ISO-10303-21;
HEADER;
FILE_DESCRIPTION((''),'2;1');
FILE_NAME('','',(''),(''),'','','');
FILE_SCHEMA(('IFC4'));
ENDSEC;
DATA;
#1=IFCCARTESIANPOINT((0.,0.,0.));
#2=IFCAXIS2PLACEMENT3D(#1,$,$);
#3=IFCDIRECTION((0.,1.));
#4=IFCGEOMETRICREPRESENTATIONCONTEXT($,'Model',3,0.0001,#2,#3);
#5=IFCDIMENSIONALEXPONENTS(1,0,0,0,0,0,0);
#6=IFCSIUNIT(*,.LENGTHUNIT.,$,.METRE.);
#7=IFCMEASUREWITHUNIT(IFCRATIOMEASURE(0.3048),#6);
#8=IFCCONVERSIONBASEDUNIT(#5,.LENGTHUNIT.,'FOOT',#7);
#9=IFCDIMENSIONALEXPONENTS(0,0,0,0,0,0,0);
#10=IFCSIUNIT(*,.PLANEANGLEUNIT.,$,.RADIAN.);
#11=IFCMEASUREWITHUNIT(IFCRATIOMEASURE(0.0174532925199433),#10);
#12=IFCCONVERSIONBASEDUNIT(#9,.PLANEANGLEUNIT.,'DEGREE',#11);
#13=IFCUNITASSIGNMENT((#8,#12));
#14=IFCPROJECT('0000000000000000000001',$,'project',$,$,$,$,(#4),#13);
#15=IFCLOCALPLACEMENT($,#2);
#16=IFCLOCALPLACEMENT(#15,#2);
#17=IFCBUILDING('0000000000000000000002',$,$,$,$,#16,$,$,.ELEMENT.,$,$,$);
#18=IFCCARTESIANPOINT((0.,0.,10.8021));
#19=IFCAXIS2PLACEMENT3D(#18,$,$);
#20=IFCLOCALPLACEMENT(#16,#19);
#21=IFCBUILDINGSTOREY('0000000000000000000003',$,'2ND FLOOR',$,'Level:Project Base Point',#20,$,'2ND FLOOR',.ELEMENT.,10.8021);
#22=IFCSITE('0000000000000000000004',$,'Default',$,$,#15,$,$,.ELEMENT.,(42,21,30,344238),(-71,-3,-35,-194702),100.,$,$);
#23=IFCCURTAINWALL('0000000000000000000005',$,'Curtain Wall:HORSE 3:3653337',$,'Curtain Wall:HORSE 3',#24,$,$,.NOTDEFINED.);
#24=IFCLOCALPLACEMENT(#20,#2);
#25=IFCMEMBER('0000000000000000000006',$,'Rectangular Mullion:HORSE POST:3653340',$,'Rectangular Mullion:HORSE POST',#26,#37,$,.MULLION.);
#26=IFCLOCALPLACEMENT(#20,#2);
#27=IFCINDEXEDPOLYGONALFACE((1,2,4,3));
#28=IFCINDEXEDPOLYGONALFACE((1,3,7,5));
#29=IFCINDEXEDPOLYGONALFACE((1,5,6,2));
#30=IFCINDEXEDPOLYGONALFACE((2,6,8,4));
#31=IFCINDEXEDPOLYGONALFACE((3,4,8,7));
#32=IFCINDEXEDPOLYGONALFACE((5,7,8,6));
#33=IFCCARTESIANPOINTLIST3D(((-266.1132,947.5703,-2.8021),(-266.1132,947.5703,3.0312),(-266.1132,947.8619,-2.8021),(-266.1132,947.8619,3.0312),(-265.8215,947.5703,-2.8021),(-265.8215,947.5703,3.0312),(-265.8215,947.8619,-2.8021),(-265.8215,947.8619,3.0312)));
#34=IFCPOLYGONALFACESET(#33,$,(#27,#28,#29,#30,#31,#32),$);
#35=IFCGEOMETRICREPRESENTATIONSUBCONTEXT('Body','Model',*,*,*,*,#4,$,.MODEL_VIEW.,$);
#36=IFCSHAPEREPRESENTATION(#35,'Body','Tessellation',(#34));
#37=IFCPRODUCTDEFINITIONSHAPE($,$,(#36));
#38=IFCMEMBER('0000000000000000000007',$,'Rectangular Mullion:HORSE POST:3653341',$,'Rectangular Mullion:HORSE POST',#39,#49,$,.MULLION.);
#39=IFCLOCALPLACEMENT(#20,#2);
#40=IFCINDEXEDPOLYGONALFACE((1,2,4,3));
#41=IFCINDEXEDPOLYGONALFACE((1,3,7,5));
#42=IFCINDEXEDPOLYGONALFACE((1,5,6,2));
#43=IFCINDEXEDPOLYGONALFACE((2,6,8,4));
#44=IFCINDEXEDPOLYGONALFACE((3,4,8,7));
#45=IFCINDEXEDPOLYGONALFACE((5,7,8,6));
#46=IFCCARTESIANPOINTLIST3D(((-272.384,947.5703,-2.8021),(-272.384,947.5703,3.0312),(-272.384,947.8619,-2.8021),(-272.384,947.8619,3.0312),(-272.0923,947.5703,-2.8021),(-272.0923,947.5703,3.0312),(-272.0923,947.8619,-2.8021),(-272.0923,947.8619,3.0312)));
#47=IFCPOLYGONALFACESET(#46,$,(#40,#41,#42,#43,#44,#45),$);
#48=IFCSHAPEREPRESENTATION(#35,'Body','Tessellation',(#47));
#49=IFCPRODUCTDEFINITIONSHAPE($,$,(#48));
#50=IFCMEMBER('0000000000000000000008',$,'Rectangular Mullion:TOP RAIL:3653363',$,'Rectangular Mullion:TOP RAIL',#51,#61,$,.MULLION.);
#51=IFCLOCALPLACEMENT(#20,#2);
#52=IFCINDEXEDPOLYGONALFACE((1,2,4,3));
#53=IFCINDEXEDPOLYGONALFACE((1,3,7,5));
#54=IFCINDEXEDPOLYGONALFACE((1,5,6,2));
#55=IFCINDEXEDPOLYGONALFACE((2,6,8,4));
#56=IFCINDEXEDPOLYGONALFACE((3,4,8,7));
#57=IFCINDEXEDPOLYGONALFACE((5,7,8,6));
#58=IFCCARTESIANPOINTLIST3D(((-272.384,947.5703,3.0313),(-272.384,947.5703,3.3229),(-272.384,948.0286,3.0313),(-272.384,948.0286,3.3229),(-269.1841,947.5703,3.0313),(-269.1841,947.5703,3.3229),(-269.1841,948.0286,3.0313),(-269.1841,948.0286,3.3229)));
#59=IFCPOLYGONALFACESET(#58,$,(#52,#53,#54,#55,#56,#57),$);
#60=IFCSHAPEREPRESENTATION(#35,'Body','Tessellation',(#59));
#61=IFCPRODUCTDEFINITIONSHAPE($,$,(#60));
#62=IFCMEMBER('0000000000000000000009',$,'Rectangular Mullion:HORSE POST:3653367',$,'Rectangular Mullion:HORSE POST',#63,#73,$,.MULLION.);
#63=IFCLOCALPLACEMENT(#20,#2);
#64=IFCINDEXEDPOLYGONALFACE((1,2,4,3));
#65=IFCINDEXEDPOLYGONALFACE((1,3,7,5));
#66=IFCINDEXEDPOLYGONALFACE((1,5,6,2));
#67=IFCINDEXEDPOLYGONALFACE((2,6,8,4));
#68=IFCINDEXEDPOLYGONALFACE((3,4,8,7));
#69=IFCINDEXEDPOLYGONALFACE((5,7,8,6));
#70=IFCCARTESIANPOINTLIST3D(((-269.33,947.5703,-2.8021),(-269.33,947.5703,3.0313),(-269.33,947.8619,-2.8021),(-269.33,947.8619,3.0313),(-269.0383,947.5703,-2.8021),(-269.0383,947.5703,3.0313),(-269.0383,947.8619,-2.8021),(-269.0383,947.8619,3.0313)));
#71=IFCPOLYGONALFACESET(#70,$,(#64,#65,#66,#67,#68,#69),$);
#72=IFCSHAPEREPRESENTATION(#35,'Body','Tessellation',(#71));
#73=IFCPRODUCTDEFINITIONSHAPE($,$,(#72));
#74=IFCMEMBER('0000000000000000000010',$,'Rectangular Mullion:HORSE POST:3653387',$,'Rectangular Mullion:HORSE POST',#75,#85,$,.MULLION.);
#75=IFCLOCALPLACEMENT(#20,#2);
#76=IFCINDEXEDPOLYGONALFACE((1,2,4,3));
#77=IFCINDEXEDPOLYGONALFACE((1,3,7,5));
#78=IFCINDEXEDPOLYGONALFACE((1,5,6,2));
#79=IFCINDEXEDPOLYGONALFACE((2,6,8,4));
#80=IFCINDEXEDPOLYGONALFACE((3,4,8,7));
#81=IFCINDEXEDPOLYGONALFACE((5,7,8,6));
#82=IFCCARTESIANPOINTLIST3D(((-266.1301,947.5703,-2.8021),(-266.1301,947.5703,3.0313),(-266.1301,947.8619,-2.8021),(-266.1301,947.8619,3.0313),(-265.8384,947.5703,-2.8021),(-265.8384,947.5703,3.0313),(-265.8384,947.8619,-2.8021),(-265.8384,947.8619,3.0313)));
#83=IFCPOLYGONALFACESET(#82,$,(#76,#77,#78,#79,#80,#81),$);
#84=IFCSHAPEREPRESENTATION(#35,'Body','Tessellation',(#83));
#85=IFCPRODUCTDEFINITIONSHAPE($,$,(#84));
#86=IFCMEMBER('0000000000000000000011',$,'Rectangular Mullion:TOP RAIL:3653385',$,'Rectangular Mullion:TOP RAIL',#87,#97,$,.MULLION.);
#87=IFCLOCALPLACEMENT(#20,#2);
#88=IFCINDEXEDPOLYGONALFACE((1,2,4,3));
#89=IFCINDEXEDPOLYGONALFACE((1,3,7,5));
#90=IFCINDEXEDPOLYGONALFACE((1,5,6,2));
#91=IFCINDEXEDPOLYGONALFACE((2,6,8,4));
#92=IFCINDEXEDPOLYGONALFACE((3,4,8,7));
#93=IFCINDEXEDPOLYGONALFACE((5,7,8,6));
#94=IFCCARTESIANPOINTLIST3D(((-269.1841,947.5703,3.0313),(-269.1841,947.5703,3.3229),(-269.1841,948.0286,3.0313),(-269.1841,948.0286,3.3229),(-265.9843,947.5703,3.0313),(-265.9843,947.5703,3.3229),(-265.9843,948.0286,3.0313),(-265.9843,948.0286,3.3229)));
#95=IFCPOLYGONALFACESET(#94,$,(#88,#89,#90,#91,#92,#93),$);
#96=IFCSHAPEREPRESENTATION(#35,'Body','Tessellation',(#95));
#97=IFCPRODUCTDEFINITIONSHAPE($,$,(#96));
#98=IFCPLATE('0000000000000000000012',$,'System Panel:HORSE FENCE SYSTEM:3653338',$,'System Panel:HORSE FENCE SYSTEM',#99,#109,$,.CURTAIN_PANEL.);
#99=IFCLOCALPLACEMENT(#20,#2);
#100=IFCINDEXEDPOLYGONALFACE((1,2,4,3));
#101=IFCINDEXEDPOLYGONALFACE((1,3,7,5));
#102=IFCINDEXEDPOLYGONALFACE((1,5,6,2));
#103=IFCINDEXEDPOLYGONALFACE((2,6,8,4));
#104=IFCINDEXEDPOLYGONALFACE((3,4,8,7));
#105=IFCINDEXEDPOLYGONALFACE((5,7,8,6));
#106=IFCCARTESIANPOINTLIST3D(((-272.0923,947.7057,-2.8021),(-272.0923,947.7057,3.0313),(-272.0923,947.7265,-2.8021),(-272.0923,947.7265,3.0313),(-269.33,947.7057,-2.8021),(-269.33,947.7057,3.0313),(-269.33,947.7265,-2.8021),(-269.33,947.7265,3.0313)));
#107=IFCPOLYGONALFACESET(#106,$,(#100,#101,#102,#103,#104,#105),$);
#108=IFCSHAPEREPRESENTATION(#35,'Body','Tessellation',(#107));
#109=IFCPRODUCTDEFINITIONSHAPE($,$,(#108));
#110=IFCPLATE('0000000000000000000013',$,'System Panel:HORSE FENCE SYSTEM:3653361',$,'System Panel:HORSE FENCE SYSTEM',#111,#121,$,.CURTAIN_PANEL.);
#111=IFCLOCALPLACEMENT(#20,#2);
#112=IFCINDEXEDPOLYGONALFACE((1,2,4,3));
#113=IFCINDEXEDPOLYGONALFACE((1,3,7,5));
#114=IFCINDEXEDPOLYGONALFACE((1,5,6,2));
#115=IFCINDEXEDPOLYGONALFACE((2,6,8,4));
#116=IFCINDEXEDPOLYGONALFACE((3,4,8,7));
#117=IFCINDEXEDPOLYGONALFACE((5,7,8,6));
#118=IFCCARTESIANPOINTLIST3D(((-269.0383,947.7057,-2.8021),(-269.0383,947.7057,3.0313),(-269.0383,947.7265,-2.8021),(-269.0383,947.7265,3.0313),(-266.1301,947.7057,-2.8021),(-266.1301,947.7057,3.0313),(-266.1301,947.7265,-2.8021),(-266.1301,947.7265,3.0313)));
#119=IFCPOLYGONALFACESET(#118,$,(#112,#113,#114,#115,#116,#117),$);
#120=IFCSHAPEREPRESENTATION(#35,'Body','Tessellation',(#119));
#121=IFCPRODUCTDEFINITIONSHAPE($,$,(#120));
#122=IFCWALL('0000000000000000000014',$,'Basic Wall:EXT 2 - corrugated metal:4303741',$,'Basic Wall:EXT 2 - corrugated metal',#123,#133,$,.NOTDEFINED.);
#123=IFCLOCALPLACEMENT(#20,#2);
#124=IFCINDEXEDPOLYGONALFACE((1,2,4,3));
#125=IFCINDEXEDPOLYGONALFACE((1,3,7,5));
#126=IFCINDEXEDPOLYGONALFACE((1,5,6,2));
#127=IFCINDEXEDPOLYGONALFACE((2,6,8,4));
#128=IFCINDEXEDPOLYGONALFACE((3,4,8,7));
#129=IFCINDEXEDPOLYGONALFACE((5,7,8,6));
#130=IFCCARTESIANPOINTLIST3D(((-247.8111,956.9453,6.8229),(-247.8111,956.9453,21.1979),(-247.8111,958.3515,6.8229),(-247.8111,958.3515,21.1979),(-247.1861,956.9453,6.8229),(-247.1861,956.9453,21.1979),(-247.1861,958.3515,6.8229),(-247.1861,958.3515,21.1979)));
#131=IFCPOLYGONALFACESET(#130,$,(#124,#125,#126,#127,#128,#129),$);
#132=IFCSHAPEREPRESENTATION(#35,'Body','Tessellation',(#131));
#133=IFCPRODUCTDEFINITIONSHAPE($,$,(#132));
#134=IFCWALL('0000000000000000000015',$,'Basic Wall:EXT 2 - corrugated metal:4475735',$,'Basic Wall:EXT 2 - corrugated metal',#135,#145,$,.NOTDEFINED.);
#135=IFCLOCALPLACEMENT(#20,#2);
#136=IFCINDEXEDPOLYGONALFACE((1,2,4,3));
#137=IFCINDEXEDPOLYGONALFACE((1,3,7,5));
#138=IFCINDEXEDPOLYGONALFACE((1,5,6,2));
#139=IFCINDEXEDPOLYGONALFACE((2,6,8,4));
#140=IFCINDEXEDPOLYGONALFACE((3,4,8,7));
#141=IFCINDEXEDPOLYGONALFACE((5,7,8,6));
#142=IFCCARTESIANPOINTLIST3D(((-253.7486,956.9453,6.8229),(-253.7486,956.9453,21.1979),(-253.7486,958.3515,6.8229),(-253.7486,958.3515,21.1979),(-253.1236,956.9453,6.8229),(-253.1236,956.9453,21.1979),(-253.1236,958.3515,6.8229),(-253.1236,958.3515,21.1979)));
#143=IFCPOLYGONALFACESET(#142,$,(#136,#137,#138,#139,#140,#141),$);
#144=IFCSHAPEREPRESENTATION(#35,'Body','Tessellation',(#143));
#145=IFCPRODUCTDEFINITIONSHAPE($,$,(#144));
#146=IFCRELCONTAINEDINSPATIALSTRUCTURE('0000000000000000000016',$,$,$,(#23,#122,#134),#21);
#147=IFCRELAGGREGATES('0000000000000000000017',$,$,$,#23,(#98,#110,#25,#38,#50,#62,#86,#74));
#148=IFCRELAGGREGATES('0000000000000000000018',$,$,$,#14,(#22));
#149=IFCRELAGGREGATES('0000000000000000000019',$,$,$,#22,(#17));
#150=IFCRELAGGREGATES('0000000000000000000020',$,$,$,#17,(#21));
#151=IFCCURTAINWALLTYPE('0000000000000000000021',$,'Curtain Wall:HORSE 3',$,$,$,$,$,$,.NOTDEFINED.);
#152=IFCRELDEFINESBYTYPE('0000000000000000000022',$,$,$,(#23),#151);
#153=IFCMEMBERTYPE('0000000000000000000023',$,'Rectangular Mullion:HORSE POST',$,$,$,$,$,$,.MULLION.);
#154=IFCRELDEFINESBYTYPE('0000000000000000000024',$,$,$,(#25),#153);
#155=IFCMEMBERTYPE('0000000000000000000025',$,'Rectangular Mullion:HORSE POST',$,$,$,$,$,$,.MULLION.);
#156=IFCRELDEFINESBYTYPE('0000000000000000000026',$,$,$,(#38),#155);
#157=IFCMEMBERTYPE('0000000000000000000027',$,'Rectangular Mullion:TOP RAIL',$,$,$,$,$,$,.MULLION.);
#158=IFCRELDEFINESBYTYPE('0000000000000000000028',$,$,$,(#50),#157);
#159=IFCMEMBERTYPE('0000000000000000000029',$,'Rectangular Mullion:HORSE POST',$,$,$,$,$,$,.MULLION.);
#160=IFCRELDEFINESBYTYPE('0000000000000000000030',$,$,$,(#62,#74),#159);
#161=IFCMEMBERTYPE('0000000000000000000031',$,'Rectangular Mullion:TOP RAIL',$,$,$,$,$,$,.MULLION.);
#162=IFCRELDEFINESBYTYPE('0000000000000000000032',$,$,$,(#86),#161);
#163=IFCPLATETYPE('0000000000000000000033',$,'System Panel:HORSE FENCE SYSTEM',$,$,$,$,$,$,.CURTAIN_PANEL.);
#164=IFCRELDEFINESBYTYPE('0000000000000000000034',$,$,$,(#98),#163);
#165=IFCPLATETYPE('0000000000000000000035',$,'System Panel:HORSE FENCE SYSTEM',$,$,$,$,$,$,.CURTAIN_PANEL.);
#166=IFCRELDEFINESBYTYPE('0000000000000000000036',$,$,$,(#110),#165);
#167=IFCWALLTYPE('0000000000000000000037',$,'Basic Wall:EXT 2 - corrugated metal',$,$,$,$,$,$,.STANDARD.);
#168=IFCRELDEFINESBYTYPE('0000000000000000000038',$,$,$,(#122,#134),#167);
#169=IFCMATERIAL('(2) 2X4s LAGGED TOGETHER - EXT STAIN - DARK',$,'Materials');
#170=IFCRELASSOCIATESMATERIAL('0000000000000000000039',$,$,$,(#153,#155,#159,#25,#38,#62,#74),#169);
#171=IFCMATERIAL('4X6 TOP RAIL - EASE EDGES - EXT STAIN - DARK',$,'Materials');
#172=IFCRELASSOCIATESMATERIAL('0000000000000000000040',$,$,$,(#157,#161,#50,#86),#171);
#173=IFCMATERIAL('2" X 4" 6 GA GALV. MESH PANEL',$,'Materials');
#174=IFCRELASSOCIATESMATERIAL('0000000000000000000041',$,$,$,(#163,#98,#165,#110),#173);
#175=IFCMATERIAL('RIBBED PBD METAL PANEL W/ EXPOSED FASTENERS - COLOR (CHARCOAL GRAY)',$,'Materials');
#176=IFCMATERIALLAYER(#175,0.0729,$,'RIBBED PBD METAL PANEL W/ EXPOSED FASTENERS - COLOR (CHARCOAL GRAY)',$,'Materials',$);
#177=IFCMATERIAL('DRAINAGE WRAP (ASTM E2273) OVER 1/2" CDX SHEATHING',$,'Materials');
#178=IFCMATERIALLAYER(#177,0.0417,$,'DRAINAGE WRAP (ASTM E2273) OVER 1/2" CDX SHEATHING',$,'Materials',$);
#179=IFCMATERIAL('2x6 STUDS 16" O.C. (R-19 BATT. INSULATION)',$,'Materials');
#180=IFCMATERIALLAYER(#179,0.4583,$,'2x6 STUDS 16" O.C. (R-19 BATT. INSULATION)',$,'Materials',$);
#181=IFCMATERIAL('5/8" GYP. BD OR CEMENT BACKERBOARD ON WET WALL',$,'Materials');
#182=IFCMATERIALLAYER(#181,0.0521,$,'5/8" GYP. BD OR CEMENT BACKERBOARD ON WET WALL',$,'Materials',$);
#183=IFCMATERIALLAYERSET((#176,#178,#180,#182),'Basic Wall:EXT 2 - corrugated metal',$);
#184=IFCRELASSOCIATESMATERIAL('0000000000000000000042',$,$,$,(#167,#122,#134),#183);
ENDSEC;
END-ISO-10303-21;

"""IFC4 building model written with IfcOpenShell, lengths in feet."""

from ifc_helpers import new_model, entity, si_unit, converted_unit, direction, frame, frame_2d, origin, origin_2d_with_axis, place, context, subcontext, project, spatial, rectangle, extrude, source, transform, mapped, material, layer, layer_set, layer_usage, material_profile, profile_set, profile_usage, type_object, type_shapes, element, aggregate, save


model = new_model("IFC4")

# Units and contexts
model_context = context("Model", 3, precision=0.0001, world=origin(), true_north=direction((0.0, 1.0)))
body_context = subcontext(model_context, "Body", "Model", "MODEL_VIEW")
ifc_project = project(units=[converted_unit("LENGTHUNIT", "FOOT", entity("IfcRatioMeasure", 0.3048), si_unit("LENGTHUNIT", "METRE"), dimensions=[1, 0, 0, 0, 0, 0, 0]), converted_unit("PLANEANGLEUNIT", "DEGREE", entity("IfcRatioMeasure", 0.0174532925199433), si_unit("PLANEANGLEUNIT", "RADIAN"), dimensions=[0, 0, 0, 0, 0, 0, 0])], contexts=[model_context])

# Site, building, storey
site_placement = place(None, origin())
site = spatial("IfcSite", under=ifc_project, at=site_placement, Name="Default", CompositionType="ELEMENT", RefLatitude=(42, 21, 30, 344238), RefLongitude=(-71, -3, -35, -194702), RefElevation=100.0)
building_placement = place(site_placement, origin())
building = spatial("IfcBuilding", under=site, at=building_placement, CompositionType="ELEMENT")
storey_placement = place(building_placement, frame((0.0, 0.0, 10.8021)))
storey = spatial("IfcBuildingStorey", under=building, at=storey_placement, Name="2ND FLOOR", ObjectType="Level:Project Base Point", LongName="2ND FLOOR", CompositionType="ELEMENT", Elevation=10.8021)

# Curtain wall, members, plates
curtain_wall_type = type_object("IfcCurtainWallType", Name="Curtain Wall:HORSE 3", PredefinedType="NOTDEFINED")
curtain_wall_placement = place(storey_placement, frame((0.0, 0.0, -10.8021)))
curtain_wall = element("IfcCurtainWall", 1, at=curtain_wall_placement, inside=storey, type_object=curtain_wall_type, Name="Curtain Wall:HORSE 3:3653337", ObjectType="Curtain Wall:HORSE 3", PredefinedType="NOTDEFINED")
ifc_material_1 = material(Name="4X6 TOP RAIL - EASE EDGES - EXT STAIN - DARK", Category="Materials")
ifc_material_profile_1 = material_profile(ifc_material_1, rectangle(XDim=0.4583, YDim=0.2917, at=origin_2d_with_axis()), Name="TOP RAIL")
ifc_profile_set_1 = profile_set([ifc_material_profile_1], Name="TOP RAIL")
placement = place(building_placement, frame((0.0, 0.0, 21.4688)))
ifc_material_2 = material(Name="(2) 2X4s LAGGED TOGETHER - EXT STAIN - DARK", Category="Materials")
ifc_material_profile_2 = material_profile(ifc_material_2, rectangle(XDim=0.2917, YDim=0.2917, at=frame_2d((0.0, 0.0), x_axis=(1.0, 0.0))), Name="HORSE POST")
ifc_profile_set_2 = profile_set([ifc_material_profile_2], Name="HORSE POST")
ifc_profile_usage_1 = profile_usage(ifc_profile_set_2)
member_type_1 = type_object("IfcMemberType", Name="Rectangular Mullion:HORSE POST", PredefinedType="MULLION", material=ifc_profile_set_2)
shared_shape_1 = source(origin(), body_context, "Body", "SweptSolid", [
    extrude(rectangle(XDim=0.2917, YDim=0.2917, at=origin_2d_with_axis()), frame((-0.1458, 0.1458, -5.8333), z_axis=(0.0, 0.0, 1.0), x_axis=(0.0, -1.0, 0.0)), (0.0, 0.0, 1.0), 5.8333),
])
type_shapes(member_type_1, [shared_shape_1])
member_1_placement = place(placement, frame((-265.8215, 947.8619, -13.4688), z_axis=(0.0, 0.0, -1.0), x_axis=(1.0, 0.0, 0.0)))
member_1 = element("IfcMember", 2, at=member_1_placement, type_object=member_type_1, material=ifc_profile_usage_1, Name="Rectangular Mullion:HORSE POST:3653340", ObjectType="Rectangular Mullion:HORSE POST", PredefinedType="MULLION", context=body_context, shape_type="MappedRepresentation", body=[
    mapped(shared_shape_1, transform((0.0, 0.0, 0.0), scale=1.0)),
])
ifc_profile_usage_2 = profile_usage(ifc_profile_set_2)
member_type_2 = type_object("IfcMemberType", Name="Rectangular Mullion:HORSE POST", PredefinedType="MULLION", material=ifc_profile_set_2)
shared_shape_2 = source(origin(), body_context, "Body", "SweptSolid", [
    extrude(rectangle(XDim=0.2917, YDim=0.2917, at=origin_2d_with_axis()), frame((-0.1458, 0.1458, -5.8333), z_axis=(0.0, 0.0, 1.0), x_axis=(0.0, -1.0, 0.0)), (0.0, 0.0, 1.0), 5.8333),
])
type_shapes(member_type_2, [shared_shape_2])
member_2_placement = place(placement, frame((-272.384, 947.8619, -7.6354), z_axis=(0.0, 0.0, 1.0), x_axis=(-1.0, 0.0, 0.0)))
member_2 = element("IfcMember", 3, at=member_2_placement, type_object=member_type_2, material=ifc_profile_usage_2, Name="Rectangular Mullion:HORSE POST:3653341", ObjectType="Rectangular Mullion:HORSE POST", PredefinedType="MULLION", context=body_context, shape_type="MappedRepresentation", body=[
    mapped(shared_shape_2, transform((0.0, 0.0, 0.0), scale=1.0)),
])
ifc_profile_usage_3 = profile_usage(ifc_profile_set_1)
member_type_3 = type_object("IfcMemberType", Name="Rectangular Mullion:TOP RAIL", PredefinedType="MULLION", material=ifc_profile_set_1)
shared_shape_3 = source(origin(), body_context, "Body", "SweptSolid", [
    extrude(rectangle(XDim=0.4583, YDim=0.2917, at=origin_2d_with_axis()), frame((-0.1458, 0.0625, -3.1999), z_axis=(0.0, 0.0, 1.0), x_axis=(0.0, -1.0, 0.0)), (0.0, 0.0, 1.0), 3.1999),
])
type_shapes(member_type_3, [shared_shape_3])
member_3_placement = place(storey_placement, frame((-269.1841, 947.8619, 3.3229), z_axis=(1.0, 0.0, 0.0), x_axis=(0.0, 0.0, 1.0)))
member_3 = element("IfcMember", 4, at=member_3_placement, type_object=member_type_3, material=ifc_profile_usage_3, Name="Rectangular Mullion:TOP RAIL:3653363", ObjectType="Rectangular Mullion:TOP RAIL", PredefinedType="MULLION", context=body_context, shape_type="MappedRepresentation", body=[
    mapped(shared_shape_3, transform((0.0, 0.0, 0.0), scale=1.0)),
])
ifc_profile_usage_4 = profile_usage(ifc_profile_set_2)
member_type_4 = type_object("IfcMemberType", Name="Rectangular Mullion:HORSE POST", PredefinedType="MULLION", material=ifc_profile_set_2)
shared_shape_4 = source(origin(), body_context, "Body", "SweptSolid", [
    extrude(rectangle(XDim=0.2917, YDim=0.2917, at=origin_2d_with_axis()), frame((0.0, 0.1458, -5.8333), z_axis=(0.0, 0.0, 1.0), x_axis=(0.0, -1.0, 0.0)), (0.0, 0.0, 1.0), 5.8333),
])
type_shapes(member_type_4, [shared_shape_4])
member_4_placement = place(storey_placement, frame((-269.1841, 947.8619, -2.8021), z_axis=(0.0, 0.0, -1.0), x_axis=(1.0, 0.0, 0.0)))
member_4 = element("IfcMember", 5, at=member_4_placement, type_object=member_type_4, material=ifc_profile_usage_4, Name="Rectangular Mullion:HORSE POST:3653367", ObjectType="Rectangular Mullion:HORSE POST", PredefinedType="MULLION", context=body_context, shape_type="MappedRepresentation", body=[
    mapped(shared_shape_4, transform((0.0, 0.0, 0.0), scale=1.0)),
])
ifc_profile_usage_5 = profile_usage(ifc_profile_set_2)
member_5_placement = place(storey_placement, frame((-265.9843, 947.8619, -2.8021), z_axis=(0.0, 0.0, -1.0), x_axis=(1.0, 0.0, 0.0)))
member_5 = element("IfcMember", 6, at=member_5_placement, type_object=member_type_4, material=ifc_profile_usage_5, Name="Rectangular Mullion:HORSE POST:3653387", ObjectType="Rectangular Mullion:HORSE POST", PredefinedType="MULLION", context=body_context, shape_type="MappedRepresentation", body=[
    mapped(shared_shape_4, transform((0.0, 0.0, 0.0), scale=1.0)),
])
ifc_profile_usage_6 = profile_usage(ifc_profile_set_1)
member_type_5 = type_object("IfcMemberType", Name="Rectangular Mullion:TOP RAIL", PredefinedType="MULLION", material=ifc_profile_set_1)
shared_shape_5 = source(origin(), body_context, "Body", "SweptSolid", [
    extrude(rectangle(XDim=0.4583, YDim=0.2917, at=origin_2d_with_axis()), frame((-0.1458, 0.0625, -3.1999), z_axis=(0.0, 0.0, 1.0), x_axis=(0.0, -1.0, 0.0)), (0.0, 0.0, 1.0), 3.1999),
])
type_shapes(member_type_5, [shared_shape_5])
member_6_placement = place(storey_placement, frame((-265.9843, 947.8619, 3.3229), z_axis=(1.0, 0.0, 0.0), x_axis=(0.0, 0.0, 1.0)))
member_6 = element("IfcMember", 7, at=member_6_placement, type_object=member_type_5, material=ifc_profile_usage_6, Name="Rectangular Mullion:TOP RAIL:3653385", ObjectType="Rectangular Mullion:TOP RAIL", PredefinedType="MULLION", context=body_context, shape_type="MappedRepresentation", body=[
    mapped(shared_shape_5, transform((0.0, 0.0, 0.0), scale=1.0)),
])
ifc_material_3 = material(Name="2\" X 4\" 6 GA GALV. MESH PANEL", Category="Materials")
plate_type_1 = type_object("IfcPlateType", Name="System Panel:HORSE FENCE SYSTEM", PredefinedType="CURTAIN_PANEL", material=ifc_material_3)
shared_shape_6 = source(origin(), body_context, "Body", "SweptSolid", [
    extrude(rectangle(XDim=0.0208, YDim=2.7624, at=frame_2d((0.0, 0.0), x_axis=(1.0, 0.0))), frame((1.3812, 0.0104, 0.0), z_axis=(0.0, 0.0, 1.0), x_axis=(0.0, 1.0, 0.0)), (0.0, 0.0, 1.0), 5.8333),
])
type_shapes(plate_type_1, [shared_shape_6])
plate_1_placement = place(curtain_wall_placement, frame((-272.0923, 947.7057, 8.0)))
plate_1 = element("IfcPlate", 8, at=plate_1_placement, type_object=plate_type_1, material=ifc_material_3, Name="System Panel:HORSE FENCE SYSTEM:3653338", ObjectType="System Panel:HORSE FENCE SYSTEM", PredefinedType="CURTAIN_PANEL", context=body_context, shape_type="MappedRepresentation", body=[
    mapped(shared_shape_6, transform((0.0, 0.0, 0.0), scale=1.0)),
])
plate_type_2 = type_object("IfcPlateType", Name="System Panel:HORSE FENCE SYSTEM", PredefinedType="CURTAIN_PANEL", material=ifc_material_3)
shared_shape_7 = source(origin(), body_context, "Body", "SweptSolid", [
    extrude(rectangle(XDim=0.0208, YDim=2.9082, at=frame_2d((0.0, 0.0), x_axis=(1.0, 0.0))), frame((1.4541, 0.0104, 0.0), z_axis=(0.0, 0.0, 1.0), x_axis=(0.0, 1.0, 0.0)), (0.0, 0.0, 1.0), 5.8333),
])
type_shapes(plate_type_2, [shared_shape_7])
plate_2_placement = place(curtain_wall_placement, frame((-269.0383, 947.7057, 8.0)))
plate_2 = element("IfcPlate", 9, at=plate_2_placement, type_object=plate_type_2, material=ifc_material_3, Name="System Panel:HORSE FENCE SYSTEM:3653361", ObjectType="System Panel:HORSE FENCE SYSTEM", PredefinedType="CURTAIN_PANEL", context=body_context, shape_type="MappedRepresentation", body=[
    mapped(shared_shape_7, transform((0.0, 0.0, 0.0), scale=1.0)),
])
aggregate(curtain_wall, [plate_1, plate_2, member_1, member_2, member_3, member_4, member_6, member_5])

# Walls
ifc_material_4 = material(Name="RIBBED PBD METAL PANEL W/ EXPOSED FASTENERS - COLOR (CHARCOAL GRAY)", Category="Materials")
ifc_layer_1 = layer(ifc_material_4, 0.0729, Name="RIBBED PBD METAL PANEL W/ EXPOSED FASTENERS - COLOR (CHARCOAL GRAY)", Category="Materials")
ifc_material_5 = material(Name="DRAINAGE WRAP (ASTM E2273) OVER 1/2\" CDX SHEATHING", Category="Materials")
ifc_layer_2 = layer(ifc_material_5, 0.0417, Name="DRAINAGE WRAP (ASTM E2273) OVER 1/2\" CDX SHEATHING", Category="Materials")
ifc_material_6 = material(Name="2x6 STUDS 16\" O.C. (R-19 BATT. INSULATION)", Category="Materials")
ifc_layer_3 = layer(ifc_material_6, 0.4583, Name="2x6 STUDS 16\" O.C. (R-19 BATT. INSULATION)", Category="Materials")
ifc_material_7 = material(Name="5/8\" GYP. BD OR CEMENT BACKERBOARD ON WET WALL", Category="Materials")
ifc_layer_4 = layer(ifc_material_7, 0.0521, Name="5/8\" GYP. BD OR CEMENT BACKERBOARD ON WET WALL", Category="Materials")
ifc_layer_set_1 = layer_set([ifc_layer_1, ifc_layer_2, ifc_layer_3, ifc_layer_4], Name="Basic Wall:EXT 2 - corrugated metal")
ifc_layer_usage_1 = layer_usage(ifc_layer_set_1, "AXIS2", "NEGATIVE", 0.3125)
wall_type_1 = type_object("IfcWallType", Name="Basic Wall:EXT 2 - corrugated metal", PredefinedType="STANDARD", material=ifc_layer_set_1)
wall_1_placement = place(storey_placement, frame((-247.4986, 956.9453, 6.8229), z_axis=(0.0, 0.0, 1.0), x_axis=(0.0, 1.0, 0.0)))
element("IfcWall", 10, at=wall_1_placement, inside=storey, type_object=wall_type_1, material=ifc_layer_usage_1, Name="Basic Wall:EXT 2 - corrugated metal:4303741", ObjectType="Basic Wall:EXT 2 - corrugated metal", PredefinedType="NOTDEFINED", context=body_context, shape_type="SweptSolid", body=[
    extrude(rectangle(XDim=1.4063, YDim=0.625, at=frame_2d((0.7031, 0.0), x_axis=(-1.0, 0.0))), origin(), (0.0, 0.0, 1.0), 14.375),
])
ifc_layer_usage_2 = layer_usage(ifc_layer_set_1, "AXIS2", "POSITIVE", -0.3125)
wall_2_placement = place(storey_placement, frame((-253.4361, 956.9453, 6.8229), z_axis=(0.0, 0.0, 1.0), x_axis=(0.0, 1.0, 0.0)))
element("IfcWall", 11, at=wall_2_placement, inside=storey, type_object=wall_type_1, material=ifc_layer_usage_2, Name="Basic Wall:EXT 2 - corrugated metal:4475735", ObjectType="Basic Wall:EXT 2 - corrugated metal", PredefinedType="NOTDEFINED", context=body_context, shape_type="SweptSolid", body=[
    extrude(rectangle(XDim=1.4062, YDim=0.625, at=frame_2d((0.7031, 0.0), x_axis=(-1.0, 0.0))), origin(), (0.0, 0.0, 1.0), 14.375),
])

save(model, "model.ifc")
